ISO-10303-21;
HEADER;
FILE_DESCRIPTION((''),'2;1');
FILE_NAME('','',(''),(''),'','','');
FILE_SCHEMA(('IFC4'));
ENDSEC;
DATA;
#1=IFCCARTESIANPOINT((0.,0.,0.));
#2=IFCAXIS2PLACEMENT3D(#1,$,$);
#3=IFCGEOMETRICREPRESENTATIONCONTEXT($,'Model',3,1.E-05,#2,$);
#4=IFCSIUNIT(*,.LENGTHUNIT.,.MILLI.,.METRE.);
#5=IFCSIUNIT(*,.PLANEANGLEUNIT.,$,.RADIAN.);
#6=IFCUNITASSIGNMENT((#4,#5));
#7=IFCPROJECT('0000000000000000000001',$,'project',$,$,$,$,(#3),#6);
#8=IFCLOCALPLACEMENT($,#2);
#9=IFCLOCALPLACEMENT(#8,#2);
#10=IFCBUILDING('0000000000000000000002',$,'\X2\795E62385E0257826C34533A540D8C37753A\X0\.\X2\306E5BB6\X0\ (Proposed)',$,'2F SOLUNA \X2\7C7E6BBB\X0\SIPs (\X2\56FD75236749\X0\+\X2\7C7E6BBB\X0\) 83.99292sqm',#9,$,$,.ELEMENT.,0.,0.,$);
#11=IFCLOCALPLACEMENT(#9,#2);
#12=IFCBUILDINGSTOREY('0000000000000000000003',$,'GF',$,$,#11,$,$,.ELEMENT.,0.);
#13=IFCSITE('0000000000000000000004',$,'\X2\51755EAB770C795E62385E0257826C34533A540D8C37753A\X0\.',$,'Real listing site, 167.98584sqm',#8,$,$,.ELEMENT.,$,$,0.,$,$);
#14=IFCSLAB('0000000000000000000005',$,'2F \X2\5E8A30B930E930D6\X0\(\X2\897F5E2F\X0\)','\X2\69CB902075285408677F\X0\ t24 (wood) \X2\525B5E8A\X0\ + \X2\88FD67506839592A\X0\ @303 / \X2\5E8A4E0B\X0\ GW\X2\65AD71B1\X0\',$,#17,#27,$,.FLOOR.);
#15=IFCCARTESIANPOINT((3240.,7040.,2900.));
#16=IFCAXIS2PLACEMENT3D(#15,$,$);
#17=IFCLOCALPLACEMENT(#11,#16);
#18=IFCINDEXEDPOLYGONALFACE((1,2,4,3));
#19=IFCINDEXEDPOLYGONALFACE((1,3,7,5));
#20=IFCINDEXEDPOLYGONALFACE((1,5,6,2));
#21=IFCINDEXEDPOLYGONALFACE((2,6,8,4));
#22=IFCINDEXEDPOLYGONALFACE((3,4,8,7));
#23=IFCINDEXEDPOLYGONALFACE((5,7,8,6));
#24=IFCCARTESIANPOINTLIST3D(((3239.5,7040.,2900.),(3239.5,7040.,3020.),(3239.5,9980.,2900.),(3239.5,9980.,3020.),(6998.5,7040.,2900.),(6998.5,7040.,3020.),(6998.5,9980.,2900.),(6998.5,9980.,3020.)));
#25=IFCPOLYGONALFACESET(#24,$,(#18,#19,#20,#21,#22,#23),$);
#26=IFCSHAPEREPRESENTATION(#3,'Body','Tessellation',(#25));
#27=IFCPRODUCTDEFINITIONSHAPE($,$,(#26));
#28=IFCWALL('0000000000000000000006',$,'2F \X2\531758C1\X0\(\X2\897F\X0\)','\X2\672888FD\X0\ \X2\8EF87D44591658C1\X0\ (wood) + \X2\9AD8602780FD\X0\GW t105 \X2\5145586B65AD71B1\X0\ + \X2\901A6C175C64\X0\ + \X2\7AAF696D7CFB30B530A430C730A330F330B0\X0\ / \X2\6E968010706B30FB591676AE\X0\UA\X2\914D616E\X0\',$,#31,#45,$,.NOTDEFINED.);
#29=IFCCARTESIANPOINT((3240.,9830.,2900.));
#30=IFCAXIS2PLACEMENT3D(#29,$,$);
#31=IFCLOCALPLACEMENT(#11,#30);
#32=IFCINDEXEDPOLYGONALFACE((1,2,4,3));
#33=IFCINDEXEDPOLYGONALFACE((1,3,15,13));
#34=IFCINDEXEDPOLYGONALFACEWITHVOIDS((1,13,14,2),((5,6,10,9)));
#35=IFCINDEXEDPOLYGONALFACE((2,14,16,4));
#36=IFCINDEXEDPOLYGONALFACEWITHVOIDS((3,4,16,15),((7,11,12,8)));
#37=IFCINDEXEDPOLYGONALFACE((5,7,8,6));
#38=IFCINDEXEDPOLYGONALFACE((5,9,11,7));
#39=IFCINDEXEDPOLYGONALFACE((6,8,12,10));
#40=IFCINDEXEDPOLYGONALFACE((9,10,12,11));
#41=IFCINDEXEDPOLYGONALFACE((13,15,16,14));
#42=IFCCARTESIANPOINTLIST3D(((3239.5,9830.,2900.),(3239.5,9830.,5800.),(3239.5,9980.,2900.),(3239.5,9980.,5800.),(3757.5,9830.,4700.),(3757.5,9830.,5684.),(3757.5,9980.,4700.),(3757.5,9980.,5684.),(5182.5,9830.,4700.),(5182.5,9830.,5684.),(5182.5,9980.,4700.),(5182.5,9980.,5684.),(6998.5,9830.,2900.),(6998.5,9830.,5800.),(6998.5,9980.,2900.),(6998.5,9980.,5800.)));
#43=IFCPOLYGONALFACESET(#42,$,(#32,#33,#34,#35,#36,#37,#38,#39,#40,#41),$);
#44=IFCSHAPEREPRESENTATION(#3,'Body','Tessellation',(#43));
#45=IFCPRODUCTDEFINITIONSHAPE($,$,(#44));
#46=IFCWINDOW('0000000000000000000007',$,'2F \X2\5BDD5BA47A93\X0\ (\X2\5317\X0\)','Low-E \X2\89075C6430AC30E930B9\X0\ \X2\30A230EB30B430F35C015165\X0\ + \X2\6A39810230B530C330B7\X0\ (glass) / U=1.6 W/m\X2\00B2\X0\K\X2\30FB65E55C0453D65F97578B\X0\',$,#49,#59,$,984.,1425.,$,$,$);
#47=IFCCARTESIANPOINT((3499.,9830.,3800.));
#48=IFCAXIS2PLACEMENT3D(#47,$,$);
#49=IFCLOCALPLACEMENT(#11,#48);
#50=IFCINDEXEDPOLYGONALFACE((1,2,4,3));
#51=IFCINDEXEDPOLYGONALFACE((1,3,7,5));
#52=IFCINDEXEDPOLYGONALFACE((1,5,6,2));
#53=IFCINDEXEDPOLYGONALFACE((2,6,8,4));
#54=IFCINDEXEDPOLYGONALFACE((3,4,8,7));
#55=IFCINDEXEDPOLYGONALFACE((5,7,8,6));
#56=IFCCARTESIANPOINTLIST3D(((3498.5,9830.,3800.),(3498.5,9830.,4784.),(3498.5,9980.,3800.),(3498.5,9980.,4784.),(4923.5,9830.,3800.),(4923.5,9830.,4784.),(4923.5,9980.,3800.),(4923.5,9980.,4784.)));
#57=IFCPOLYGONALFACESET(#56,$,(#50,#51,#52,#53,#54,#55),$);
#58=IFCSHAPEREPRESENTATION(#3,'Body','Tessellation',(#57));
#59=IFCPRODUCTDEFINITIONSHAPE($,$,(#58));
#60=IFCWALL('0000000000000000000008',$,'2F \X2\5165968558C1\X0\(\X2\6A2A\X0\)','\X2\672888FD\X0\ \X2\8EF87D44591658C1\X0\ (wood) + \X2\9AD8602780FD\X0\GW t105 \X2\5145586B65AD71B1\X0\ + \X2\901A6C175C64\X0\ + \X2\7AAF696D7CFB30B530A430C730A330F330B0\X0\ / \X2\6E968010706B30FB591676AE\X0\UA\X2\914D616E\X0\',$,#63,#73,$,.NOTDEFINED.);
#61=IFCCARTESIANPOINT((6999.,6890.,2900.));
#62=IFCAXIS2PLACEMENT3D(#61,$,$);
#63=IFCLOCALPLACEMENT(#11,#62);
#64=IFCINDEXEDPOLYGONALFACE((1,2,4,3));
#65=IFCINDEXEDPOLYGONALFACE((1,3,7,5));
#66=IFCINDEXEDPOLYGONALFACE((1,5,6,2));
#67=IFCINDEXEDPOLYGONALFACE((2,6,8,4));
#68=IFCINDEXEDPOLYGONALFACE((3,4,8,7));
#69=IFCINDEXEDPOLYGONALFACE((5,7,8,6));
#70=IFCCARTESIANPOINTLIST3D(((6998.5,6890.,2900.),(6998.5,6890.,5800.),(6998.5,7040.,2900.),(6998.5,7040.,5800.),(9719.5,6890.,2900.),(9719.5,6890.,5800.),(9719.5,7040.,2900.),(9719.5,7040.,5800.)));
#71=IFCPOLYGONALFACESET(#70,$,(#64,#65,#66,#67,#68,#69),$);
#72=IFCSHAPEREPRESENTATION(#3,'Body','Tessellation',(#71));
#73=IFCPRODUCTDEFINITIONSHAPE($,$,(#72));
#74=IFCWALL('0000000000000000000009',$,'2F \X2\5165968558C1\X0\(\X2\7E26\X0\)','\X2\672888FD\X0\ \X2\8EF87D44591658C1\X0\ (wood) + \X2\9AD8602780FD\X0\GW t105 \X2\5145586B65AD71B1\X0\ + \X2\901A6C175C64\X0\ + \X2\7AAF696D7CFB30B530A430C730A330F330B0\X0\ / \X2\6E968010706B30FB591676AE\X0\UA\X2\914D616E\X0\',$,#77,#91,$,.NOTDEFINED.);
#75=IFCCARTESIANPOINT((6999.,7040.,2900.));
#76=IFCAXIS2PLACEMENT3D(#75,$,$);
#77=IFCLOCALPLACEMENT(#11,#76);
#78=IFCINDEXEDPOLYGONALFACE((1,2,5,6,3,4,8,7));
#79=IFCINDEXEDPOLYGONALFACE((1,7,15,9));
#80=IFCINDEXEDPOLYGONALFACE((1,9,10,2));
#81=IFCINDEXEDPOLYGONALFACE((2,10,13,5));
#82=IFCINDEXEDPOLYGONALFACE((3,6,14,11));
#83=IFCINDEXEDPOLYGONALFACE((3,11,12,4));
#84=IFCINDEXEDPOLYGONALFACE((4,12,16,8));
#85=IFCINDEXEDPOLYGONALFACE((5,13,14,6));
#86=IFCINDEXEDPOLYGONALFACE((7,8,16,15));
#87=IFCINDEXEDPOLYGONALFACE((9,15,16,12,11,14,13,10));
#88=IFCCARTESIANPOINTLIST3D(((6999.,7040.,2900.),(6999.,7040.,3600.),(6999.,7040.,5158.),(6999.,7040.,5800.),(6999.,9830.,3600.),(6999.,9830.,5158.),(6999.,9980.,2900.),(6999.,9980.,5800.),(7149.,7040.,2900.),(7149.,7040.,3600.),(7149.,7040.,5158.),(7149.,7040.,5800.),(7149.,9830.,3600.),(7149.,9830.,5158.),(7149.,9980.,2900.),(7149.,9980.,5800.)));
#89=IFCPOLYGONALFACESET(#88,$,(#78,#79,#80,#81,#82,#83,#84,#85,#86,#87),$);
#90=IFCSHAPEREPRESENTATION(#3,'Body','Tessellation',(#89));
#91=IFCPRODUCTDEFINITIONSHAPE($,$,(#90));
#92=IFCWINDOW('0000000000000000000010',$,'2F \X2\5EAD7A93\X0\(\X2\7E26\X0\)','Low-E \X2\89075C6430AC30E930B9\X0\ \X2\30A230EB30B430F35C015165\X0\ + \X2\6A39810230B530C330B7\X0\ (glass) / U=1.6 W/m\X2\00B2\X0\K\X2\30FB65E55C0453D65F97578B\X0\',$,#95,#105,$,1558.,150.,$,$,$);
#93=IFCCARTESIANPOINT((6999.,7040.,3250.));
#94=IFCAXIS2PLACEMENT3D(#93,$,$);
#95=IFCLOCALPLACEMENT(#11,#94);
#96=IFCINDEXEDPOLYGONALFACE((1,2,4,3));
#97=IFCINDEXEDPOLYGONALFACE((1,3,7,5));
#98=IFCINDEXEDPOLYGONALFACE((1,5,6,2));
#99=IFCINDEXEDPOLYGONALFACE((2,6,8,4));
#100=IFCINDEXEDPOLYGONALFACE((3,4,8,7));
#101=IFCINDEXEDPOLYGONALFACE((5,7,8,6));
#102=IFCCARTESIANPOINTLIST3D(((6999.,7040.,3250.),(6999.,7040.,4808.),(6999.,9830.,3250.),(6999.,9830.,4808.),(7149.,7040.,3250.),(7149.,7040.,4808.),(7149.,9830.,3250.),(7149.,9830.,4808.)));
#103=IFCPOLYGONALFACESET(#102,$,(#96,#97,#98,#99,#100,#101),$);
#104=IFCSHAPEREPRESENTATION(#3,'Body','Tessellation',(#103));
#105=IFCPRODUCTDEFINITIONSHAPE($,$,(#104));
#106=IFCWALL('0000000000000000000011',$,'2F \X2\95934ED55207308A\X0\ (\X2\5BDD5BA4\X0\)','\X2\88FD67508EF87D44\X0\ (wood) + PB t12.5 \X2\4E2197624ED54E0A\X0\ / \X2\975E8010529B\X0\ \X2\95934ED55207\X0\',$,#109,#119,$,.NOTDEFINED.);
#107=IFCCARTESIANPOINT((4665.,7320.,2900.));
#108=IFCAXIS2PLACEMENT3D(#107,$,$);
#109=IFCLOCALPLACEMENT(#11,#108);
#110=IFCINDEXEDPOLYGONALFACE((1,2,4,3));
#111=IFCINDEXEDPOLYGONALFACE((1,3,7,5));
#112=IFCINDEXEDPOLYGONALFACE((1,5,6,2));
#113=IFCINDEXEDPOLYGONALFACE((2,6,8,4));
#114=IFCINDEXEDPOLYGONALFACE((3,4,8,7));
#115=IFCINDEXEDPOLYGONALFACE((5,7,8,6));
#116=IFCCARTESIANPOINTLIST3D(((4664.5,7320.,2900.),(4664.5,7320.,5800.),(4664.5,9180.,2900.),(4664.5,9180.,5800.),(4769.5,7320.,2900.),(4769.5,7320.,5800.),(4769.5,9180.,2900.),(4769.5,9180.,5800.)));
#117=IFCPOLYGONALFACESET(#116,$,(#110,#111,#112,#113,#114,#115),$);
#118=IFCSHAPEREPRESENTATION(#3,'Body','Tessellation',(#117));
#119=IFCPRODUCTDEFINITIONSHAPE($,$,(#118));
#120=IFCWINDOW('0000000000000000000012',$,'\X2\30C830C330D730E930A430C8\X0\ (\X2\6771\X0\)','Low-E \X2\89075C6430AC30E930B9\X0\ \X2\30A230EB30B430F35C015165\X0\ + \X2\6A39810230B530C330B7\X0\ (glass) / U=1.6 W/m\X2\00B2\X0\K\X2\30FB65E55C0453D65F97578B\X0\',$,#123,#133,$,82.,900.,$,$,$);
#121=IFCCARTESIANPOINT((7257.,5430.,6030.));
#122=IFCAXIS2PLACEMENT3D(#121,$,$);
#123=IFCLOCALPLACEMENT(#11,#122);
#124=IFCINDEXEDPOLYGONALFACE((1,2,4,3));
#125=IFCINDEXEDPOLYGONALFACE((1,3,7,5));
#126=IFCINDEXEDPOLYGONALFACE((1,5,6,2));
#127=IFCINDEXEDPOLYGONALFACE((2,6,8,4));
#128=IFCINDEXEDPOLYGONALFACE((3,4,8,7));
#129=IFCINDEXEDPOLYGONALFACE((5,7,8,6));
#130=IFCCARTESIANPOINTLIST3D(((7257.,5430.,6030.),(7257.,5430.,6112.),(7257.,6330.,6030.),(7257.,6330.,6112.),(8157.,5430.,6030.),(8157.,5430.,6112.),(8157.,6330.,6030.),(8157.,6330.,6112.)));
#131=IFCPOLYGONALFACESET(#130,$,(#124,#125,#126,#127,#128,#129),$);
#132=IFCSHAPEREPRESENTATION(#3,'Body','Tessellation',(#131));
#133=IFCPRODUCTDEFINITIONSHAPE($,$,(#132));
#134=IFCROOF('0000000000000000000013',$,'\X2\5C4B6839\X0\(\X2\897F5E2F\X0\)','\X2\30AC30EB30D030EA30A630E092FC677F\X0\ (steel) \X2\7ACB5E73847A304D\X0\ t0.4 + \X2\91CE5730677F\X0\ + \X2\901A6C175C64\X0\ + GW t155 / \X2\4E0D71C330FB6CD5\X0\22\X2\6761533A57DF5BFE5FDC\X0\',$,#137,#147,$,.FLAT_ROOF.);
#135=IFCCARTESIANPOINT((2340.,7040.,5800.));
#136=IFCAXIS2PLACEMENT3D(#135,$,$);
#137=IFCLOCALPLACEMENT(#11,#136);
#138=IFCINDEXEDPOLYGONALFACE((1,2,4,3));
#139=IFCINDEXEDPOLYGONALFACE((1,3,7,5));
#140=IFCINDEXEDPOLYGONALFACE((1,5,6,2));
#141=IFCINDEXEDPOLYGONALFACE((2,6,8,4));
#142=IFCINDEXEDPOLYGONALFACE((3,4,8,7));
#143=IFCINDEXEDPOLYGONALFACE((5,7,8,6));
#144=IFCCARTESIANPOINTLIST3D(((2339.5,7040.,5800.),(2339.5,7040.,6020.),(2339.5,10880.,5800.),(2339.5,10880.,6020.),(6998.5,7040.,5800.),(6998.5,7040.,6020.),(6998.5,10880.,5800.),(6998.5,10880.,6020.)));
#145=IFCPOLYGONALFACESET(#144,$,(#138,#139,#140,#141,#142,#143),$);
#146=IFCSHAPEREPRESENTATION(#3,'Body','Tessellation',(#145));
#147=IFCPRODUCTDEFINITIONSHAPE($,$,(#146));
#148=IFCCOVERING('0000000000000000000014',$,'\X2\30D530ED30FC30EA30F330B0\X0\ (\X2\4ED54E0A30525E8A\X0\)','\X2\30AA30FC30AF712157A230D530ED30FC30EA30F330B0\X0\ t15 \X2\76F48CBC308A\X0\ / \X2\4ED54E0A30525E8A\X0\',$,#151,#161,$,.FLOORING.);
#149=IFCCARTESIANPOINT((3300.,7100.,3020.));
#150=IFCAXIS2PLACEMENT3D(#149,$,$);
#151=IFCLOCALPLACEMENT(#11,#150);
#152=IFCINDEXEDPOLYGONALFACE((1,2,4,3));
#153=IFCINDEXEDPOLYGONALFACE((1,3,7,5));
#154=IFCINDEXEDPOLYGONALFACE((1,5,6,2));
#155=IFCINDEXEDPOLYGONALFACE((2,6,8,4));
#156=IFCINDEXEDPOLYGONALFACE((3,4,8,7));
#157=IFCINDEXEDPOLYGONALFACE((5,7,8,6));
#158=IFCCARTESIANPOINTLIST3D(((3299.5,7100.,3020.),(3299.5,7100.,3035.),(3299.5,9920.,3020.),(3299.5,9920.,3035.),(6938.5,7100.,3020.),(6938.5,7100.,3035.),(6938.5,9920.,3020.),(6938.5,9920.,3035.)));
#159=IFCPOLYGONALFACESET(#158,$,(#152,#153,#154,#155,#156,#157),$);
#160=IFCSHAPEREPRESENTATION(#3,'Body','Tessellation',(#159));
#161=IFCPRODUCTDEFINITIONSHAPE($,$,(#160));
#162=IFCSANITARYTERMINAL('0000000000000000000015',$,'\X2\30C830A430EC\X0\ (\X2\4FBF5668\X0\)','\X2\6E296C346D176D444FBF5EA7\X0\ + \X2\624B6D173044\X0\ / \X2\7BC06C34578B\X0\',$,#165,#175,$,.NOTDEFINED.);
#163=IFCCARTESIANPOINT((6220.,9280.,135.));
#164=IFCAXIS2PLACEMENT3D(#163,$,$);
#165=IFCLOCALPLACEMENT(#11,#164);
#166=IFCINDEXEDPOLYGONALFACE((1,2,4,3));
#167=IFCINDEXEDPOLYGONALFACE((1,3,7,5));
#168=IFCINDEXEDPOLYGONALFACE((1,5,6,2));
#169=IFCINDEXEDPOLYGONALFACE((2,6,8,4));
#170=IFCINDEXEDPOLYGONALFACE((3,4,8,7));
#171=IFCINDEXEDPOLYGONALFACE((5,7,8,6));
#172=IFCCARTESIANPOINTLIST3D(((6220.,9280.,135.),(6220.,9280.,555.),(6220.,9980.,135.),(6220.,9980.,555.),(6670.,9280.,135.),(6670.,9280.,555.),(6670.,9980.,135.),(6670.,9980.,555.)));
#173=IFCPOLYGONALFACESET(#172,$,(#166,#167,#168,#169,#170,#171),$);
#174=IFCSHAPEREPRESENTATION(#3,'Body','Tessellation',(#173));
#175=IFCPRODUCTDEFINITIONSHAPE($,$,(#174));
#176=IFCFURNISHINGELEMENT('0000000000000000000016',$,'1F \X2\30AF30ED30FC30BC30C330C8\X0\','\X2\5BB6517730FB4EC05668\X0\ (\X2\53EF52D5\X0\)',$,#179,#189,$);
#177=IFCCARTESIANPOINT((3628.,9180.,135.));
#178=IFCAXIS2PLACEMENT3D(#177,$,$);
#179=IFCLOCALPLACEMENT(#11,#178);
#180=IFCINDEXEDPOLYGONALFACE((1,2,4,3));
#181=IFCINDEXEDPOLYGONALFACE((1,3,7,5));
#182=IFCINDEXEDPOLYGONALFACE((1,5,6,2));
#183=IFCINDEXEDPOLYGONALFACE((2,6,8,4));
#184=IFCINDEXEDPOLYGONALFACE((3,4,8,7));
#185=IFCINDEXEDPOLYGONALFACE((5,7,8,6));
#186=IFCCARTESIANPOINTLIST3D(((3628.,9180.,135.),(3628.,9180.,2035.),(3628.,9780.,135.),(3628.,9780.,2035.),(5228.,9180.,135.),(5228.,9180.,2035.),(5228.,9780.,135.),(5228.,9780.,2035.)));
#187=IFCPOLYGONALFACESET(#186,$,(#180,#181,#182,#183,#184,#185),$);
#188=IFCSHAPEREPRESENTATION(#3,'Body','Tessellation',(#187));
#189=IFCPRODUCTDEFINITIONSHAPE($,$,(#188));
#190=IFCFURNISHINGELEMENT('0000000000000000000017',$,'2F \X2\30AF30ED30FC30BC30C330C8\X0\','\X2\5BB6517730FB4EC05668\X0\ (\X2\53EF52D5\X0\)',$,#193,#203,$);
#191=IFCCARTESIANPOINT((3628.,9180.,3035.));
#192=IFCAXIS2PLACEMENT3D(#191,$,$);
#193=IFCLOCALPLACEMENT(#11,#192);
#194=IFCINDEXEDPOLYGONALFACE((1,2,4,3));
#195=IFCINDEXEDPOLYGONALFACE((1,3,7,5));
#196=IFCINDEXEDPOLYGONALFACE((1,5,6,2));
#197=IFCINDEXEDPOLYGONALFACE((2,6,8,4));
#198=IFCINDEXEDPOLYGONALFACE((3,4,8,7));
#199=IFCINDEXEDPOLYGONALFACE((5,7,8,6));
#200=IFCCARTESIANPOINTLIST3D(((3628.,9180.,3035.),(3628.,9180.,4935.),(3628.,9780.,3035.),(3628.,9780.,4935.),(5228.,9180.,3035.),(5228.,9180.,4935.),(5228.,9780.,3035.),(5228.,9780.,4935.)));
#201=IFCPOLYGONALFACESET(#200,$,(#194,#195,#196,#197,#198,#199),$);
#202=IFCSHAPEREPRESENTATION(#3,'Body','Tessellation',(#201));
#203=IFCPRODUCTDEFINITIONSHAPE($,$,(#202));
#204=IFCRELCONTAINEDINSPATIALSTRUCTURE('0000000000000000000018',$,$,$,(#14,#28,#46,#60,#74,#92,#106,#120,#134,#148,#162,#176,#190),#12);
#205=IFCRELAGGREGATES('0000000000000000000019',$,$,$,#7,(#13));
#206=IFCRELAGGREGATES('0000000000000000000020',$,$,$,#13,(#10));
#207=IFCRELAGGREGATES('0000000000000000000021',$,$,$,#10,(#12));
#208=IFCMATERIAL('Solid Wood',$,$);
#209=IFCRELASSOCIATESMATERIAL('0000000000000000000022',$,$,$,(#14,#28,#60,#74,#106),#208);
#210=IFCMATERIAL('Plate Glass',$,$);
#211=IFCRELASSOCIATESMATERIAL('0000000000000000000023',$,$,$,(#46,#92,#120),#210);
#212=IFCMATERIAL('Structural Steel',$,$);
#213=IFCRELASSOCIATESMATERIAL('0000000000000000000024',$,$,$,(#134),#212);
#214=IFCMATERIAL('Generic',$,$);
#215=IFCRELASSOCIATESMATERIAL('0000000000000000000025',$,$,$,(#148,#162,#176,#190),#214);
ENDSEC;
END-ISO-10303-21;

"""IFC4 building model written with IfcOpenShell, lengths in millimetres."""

from ifc_helpers import new_model, si_unit, frame, frame_2d, origin, place, context, project, spatial, rectangle, extrude, material, element, fill, save


model = new_model("IFC4")

# Units and contexts
model_context = context("Model", 3, precision=1e-05, world=origin())
ifc_project = project(units=[si_unit("LENGTHUNIT", "METRE", prefix="MILLI"), si_unit("PLANEANGLEUNIT", "RADIAN")], contexts=[model_context])

# Site, building, storey
site_placement = place(None, origin())
site = spatial("IfcSite", under=ifc_project, at=site_placement, Name="兵庫県神戸市垂水区名谷町.", ObjectType="Real listing site, 167.98584sqm", CompositionType="ELEMENT", RefElevation=0.0)
building_placement = place(site_placement, origin())
building = spatial("IfcBuilding", under=site, at=building_placement, Name="神戸市垂水区名谷町.の家 (Proposed)", ObjectType="2F SOLUNA 籾殻SIPs (国産杉+籾殻) 83.99292sqm", CompositionType="ELEMENT", ElevationOfRefHeight=0.0, ElevationOfTerrain=0.0)
storey_placement = place(building_placement, origin())
storey = spatial("IfcBuildingStorey", under=building, at=storey_placement, Name="GF", CompositionType="ELEMENT", Elevation=0.0)

# Slab
ifc_material_1 = material(Name="Solid Wood")
slab_placement = place(storey_placement, frame((3240.0, 7040.0, 2900.0)))
element("IfcSlab", 1, at=slab_placement, inside=storey, material=ifc_material_1, Name="2F 床スラブ(西帯)", Description="構造用合板 t24 (wood) 剛床 + 製材根太 @303 / 床下 GW断熱", PredefinedType="FLOOR", context=model_context, shape_type="SweptSolid", body=[
    extrude(rectangle(XDim=3759.0, YDim=2940.0, at=frame_2d((1879.0, 1470.0))), frame((3240.0, 7040.0, 2900.0)), (0.0, 0.0, 1.0), 120.0),
])

# Wall, opening, window
wall_1_placement = place(storey_placement, frame((3240.0, 9830.0, 2900.0)))
wall_1 = element("IfcWall", 2, at=wall_1_placement, inside=storey, material=ifc_material_1, Name="2F 北壁(西)", Description="木製 軸組外壁 (wood) + 高性能GW t105 充填断熱 + 通気層 + 窯業系サイディング / 準耐火・外皮UA配慮", PredefinedType="NOTDEFINED", context=model_context, shape_type="SweptSolid", body=[
    extrude(rectangle(XDim=3759.0, YDim=150.0, at=frame_2d((1879.0, 75.0))), frame((3240.0, 9830.0, 2900.0)), (0.0, 0.0, 1.0), 2900.0),
])
opening_1_placement = place(storey_placement, frame((3499.0, 9830.0, 3800.0)))
opening_1 = element("IfcOpeningElement", 3, at=opening_1_placement, cuts=wall_1, PredefinedType="NOTDEFINED", context=model_context, shape_type="SweptSolid", body=[
    extrude(rectangle(XDim=1425.0, YDim=150.0, at=frame_2d((712.0, 75.0))), frame((3499.0, 9830.0, 3800.0)), (0.0, 0.0, 1.0), 984.0),
])
ifc_material_2 = material(Name="Plate Glass")
window_1_placement = place(storey_placement, frame((3499.0, 9830.0, 3800.0)))
window_1 = element("IfcWindow", 4, at=window_1_placement, inside=storey, material=ifc_material_2, Name="2F 寝室窓 (北)", Description="Low-E 複層ガラス アルゴン封入 + 樹脂サッシ (glass) / U=1.6 W/m²K・日射取得型", OverallHeight=984.0, OverallWidth=1425.0, context=model_context, shape_type="SweptSolid", body=[
    extrude(rectangle(XDim=1425.0, YDim=150.0, at=frame_2d((712.0, 75.0))), frame((3499.0, 9830.0, 3800.0)), (0.0, 0.0, 1.0), 984.0),
])
fill(opening_1, window_1)

# Wall
wall_2_placement = place(storey_placement, frame((6999.0, 6890.0, 2900.0)))
element("IfcWall", 5, at=wall_2_placement, inside=storey, material=ifc_material_1, Name="2F 入隅壁(横)", Description="木製 軸組外壁 (wood) + 高性能GW t105 充填断熱 + 通気層 + 窯業系サイディング / 準耐火・外皮UA配慮", PredefinedType="NOTDEFINED", context=model_context, shape_type="SweptSolid", body=[
    extrude(rectangle(XDim=2721.0, YDim=150.0, at=frame_2d((1360.0, 75.0))), frame((6999.0, 6890.0, 2900.0)), (0.0, 0.0, 1.0), 2900.0),
])

# Wall, opening, window
wall_3_placement = place(storey_placement, frame((6999.0, 7040.0, 2900.0)))
wall_3 = element("IfcWall", 6, at=wall_3_placement, inside=storey, material=ifc_material_1, Name="2F 入隅壁(縦)", Description="木製 軸組外壁 (wood) + 高性能GW t105 充填断熱 + 通気層 + 窯業系サイディング / 準耐火・外皮UA配慮", PredefinedType="NOTDEFINED", context=model_context, shape_type="SweptSolid", body=[
    extrude(rectangle(XDim=150.0, YDim=2940.0, at=frame_2d((75.0, 1470.0))), frame((6999.0, 7040.0, 2900.0)), (0.0, 0.0, 1.0), 2900.0),
])
opening_2_placement = place(storey_placement, frame((6999.0, 7040.0, 3250.0)))
opening_2 = element("IfcOpeningElement", 7, at=opening_2_placement, cuts=wall_3, PredefinedType="NOTDEFINED", context=model_context, shape_type="SweptSolid", body=[
    extrude(rectangle(XDim=150.0, YDim=2790.0, at=frame_2d((75.0, 1395.0))), frame((6999.0, 7040.0, 3250.0)), (0.0, 0.0, 1.0), 1558.0),
])
window_2_placement = place(storey_placement, frame((6999.0, 7040.0, 3250.0)))
window_2 = element("IfcWindow", 8, at=window_2_placement, inside=storey, material=ifc_material_2, Name="2F 庭窓(縦)", Description="Low-E 複層ガラス アルゴン封入 + 樹脂サッシ (glass) / U=1.6 W/m²K・日射取得型", OverallHeight=1558.0, OverallWidth=150.0, context=model_context, shape_type="SweptSolid", body=[
    extrude(rectangle(XDim=150.0, YDim=2790.0, at=frame_2d((75.0, 1395.0))), frame((6999.0, 7040.0, 3250.0)), (0.0, 0.0, 1.0), 1558.0),
])
fill(opening_2, window_2)

# Wall
wall_4_placement = place(storey_placement, frame((4665.0, 7320.0, 2900.0)))
element("IfcWall", 9, at=wall_4_placement, inside=storey, material=ifc_material_1, Name="2F 間仕切り (寝室)", Description="製材軸組 (wood) + PB t12.5 両面仕上 / 非耐力 間仕切", PredefinedType="NOTDEFINED", context=model_context, shape_type="SweptSolid", body=[
    extrude(rectangle(XDim=105.0, YDim=1860.0, at=frame_2d((52.0, 930.0))), frame((4665.0, 7320.0, 2900.0)), (0.0, 0.0, 1.0), 2900.0),
])

# Window
window_3_placement = place(storey_placement, frame((7257.0, 5430.0, 6030.0)))
element("IfcWindow", 10, at=window_3_placement, inside=storey, material=ifc_material_2, Name="トップライト (東)", Description="Low-E 複層ガラス アルゴン封入 + 樹脂サッシ (glass) / U=1.6 W/m²K・日射取得型", OverallHeight=82.0, OverallWidth=900.0, context=model_context, shape_type="SweptSolid", body=[
    extrude(rectangle(XDim=900.0, YDim=900.0, at=frame_2d((450.0, 450.0))), frame((7257.0, 5430.0, 6030.0)), (0.0, 0.0, 1.0), 82.0),
])

# Roof
ifc_material_3 = material(Name="Structural Steel")
for number, where, name in (
    (11, (2340.0, 7040.0, 5800.0), "屋根(西帯)"),
):
    element("IfcRoof", number, at=place(storey_placement, frame(where)), inside=storey, material=ifc_material_3, Name=name, Description="ガルバリウム鋼板 (steel) 立平葺き t0.4 + 野地板 + 通気層 + GW t155 / 不燃・法22条区域対応", PredefinedType="FLAT_ROOF", context=model_context, shape_type="SweptSolid", body=[
        extrude(rectangle(XDim=4659.0, YDim=3840.0, at=frame_2d((2329.0, 1920.0))), frame((2340.0, 7040.0, 5800.0)), (0.0, 0.0, 1.0), 220.0),
    ])

# Covering
ifc_material_4 = material(Name="Generic")
covering_placement = place(storey_placement, frame((3300.0, 7100.0, 3020.0)))
element("IfcCovering", 12, at=covering_placement, inside=storey, material=ifc_material_4, Name="フローリング (仕上げ床)", Description="オーク無垢フローリング t15 直貼り / 仕上げ床", PredefinedType="FLOORING", context=model_context, shape_type="SweptSolid", body=[
    extrude(rectangle(XDim=3639.0, YDim=2820.0, at=frame_2d((1819.0, 1410.0))), frame((3300.0, 7100.0, 3020.0)), (0.0, 0.0, 1.0), 15.0),
])

# Sanitary terminal
sanitary_terminal_placement = place(storey_placement, frame((6220.0, 9280.0, 135.0)))
element("IfcSanitaryTerminal", 13, at=sanitary_terminal_placement, inside=storey, material=ifc_material_4, Name="トイレ (便器)", Description="温水洗浄便座 + 手洗い / 節水型", PredefinedType="NOTDEFINED", context=model_context, shape_type="SweptSolid", body=[
    extrude(rectangle(XDim=450.0, YDim=700.0, at=frame_2d((225.0, 350.0))), frame((6220.0, 9280.0, 135.0)), (0.0, 0.0, 1.0), 420.0),
])

# Furnishing elements
furnishing_1_placement = place(storey_placement, frame((3628.0, 9180.0, 135.0)))
element("IfcFurnishingElement", 14, at=furnishing_1_placement, inside=storey, material=ifc_material_4, Name="1F クローゼット", Description="家具・什器 (可動)", context=model_context, shape_type="SweptSolid", body=[
    extrude(rectangle(XDim=1600.0, YDim=600.0, at=frame_2d((800.0, 300.0))), frame((3628.0, 9180.0, 135.0)), (0.0, 0.0, 1.0), 1900.0),
])
furnishing_2_placement = place(storey_placement, frame((3628.0, 9180.0, 3035.0)))
element("IfcFurnishingElement", 15, at=furnishing_2_placement, inside=storey, material=ifc_material_4, Name="2F クローゼット", Description="家具・什器 (可動)", context=model_context, shape_type="SweptSolid", body=[
    extrude(rectangle(XDim=1600.0, YDim=600.0, at=frame_2d((800.0, 300.0))), frame((3628.0, 9180.0, 3035.0)), (0.0, 0.0, 1.0), 1900.0),
])

save(model, "model.ifc")
